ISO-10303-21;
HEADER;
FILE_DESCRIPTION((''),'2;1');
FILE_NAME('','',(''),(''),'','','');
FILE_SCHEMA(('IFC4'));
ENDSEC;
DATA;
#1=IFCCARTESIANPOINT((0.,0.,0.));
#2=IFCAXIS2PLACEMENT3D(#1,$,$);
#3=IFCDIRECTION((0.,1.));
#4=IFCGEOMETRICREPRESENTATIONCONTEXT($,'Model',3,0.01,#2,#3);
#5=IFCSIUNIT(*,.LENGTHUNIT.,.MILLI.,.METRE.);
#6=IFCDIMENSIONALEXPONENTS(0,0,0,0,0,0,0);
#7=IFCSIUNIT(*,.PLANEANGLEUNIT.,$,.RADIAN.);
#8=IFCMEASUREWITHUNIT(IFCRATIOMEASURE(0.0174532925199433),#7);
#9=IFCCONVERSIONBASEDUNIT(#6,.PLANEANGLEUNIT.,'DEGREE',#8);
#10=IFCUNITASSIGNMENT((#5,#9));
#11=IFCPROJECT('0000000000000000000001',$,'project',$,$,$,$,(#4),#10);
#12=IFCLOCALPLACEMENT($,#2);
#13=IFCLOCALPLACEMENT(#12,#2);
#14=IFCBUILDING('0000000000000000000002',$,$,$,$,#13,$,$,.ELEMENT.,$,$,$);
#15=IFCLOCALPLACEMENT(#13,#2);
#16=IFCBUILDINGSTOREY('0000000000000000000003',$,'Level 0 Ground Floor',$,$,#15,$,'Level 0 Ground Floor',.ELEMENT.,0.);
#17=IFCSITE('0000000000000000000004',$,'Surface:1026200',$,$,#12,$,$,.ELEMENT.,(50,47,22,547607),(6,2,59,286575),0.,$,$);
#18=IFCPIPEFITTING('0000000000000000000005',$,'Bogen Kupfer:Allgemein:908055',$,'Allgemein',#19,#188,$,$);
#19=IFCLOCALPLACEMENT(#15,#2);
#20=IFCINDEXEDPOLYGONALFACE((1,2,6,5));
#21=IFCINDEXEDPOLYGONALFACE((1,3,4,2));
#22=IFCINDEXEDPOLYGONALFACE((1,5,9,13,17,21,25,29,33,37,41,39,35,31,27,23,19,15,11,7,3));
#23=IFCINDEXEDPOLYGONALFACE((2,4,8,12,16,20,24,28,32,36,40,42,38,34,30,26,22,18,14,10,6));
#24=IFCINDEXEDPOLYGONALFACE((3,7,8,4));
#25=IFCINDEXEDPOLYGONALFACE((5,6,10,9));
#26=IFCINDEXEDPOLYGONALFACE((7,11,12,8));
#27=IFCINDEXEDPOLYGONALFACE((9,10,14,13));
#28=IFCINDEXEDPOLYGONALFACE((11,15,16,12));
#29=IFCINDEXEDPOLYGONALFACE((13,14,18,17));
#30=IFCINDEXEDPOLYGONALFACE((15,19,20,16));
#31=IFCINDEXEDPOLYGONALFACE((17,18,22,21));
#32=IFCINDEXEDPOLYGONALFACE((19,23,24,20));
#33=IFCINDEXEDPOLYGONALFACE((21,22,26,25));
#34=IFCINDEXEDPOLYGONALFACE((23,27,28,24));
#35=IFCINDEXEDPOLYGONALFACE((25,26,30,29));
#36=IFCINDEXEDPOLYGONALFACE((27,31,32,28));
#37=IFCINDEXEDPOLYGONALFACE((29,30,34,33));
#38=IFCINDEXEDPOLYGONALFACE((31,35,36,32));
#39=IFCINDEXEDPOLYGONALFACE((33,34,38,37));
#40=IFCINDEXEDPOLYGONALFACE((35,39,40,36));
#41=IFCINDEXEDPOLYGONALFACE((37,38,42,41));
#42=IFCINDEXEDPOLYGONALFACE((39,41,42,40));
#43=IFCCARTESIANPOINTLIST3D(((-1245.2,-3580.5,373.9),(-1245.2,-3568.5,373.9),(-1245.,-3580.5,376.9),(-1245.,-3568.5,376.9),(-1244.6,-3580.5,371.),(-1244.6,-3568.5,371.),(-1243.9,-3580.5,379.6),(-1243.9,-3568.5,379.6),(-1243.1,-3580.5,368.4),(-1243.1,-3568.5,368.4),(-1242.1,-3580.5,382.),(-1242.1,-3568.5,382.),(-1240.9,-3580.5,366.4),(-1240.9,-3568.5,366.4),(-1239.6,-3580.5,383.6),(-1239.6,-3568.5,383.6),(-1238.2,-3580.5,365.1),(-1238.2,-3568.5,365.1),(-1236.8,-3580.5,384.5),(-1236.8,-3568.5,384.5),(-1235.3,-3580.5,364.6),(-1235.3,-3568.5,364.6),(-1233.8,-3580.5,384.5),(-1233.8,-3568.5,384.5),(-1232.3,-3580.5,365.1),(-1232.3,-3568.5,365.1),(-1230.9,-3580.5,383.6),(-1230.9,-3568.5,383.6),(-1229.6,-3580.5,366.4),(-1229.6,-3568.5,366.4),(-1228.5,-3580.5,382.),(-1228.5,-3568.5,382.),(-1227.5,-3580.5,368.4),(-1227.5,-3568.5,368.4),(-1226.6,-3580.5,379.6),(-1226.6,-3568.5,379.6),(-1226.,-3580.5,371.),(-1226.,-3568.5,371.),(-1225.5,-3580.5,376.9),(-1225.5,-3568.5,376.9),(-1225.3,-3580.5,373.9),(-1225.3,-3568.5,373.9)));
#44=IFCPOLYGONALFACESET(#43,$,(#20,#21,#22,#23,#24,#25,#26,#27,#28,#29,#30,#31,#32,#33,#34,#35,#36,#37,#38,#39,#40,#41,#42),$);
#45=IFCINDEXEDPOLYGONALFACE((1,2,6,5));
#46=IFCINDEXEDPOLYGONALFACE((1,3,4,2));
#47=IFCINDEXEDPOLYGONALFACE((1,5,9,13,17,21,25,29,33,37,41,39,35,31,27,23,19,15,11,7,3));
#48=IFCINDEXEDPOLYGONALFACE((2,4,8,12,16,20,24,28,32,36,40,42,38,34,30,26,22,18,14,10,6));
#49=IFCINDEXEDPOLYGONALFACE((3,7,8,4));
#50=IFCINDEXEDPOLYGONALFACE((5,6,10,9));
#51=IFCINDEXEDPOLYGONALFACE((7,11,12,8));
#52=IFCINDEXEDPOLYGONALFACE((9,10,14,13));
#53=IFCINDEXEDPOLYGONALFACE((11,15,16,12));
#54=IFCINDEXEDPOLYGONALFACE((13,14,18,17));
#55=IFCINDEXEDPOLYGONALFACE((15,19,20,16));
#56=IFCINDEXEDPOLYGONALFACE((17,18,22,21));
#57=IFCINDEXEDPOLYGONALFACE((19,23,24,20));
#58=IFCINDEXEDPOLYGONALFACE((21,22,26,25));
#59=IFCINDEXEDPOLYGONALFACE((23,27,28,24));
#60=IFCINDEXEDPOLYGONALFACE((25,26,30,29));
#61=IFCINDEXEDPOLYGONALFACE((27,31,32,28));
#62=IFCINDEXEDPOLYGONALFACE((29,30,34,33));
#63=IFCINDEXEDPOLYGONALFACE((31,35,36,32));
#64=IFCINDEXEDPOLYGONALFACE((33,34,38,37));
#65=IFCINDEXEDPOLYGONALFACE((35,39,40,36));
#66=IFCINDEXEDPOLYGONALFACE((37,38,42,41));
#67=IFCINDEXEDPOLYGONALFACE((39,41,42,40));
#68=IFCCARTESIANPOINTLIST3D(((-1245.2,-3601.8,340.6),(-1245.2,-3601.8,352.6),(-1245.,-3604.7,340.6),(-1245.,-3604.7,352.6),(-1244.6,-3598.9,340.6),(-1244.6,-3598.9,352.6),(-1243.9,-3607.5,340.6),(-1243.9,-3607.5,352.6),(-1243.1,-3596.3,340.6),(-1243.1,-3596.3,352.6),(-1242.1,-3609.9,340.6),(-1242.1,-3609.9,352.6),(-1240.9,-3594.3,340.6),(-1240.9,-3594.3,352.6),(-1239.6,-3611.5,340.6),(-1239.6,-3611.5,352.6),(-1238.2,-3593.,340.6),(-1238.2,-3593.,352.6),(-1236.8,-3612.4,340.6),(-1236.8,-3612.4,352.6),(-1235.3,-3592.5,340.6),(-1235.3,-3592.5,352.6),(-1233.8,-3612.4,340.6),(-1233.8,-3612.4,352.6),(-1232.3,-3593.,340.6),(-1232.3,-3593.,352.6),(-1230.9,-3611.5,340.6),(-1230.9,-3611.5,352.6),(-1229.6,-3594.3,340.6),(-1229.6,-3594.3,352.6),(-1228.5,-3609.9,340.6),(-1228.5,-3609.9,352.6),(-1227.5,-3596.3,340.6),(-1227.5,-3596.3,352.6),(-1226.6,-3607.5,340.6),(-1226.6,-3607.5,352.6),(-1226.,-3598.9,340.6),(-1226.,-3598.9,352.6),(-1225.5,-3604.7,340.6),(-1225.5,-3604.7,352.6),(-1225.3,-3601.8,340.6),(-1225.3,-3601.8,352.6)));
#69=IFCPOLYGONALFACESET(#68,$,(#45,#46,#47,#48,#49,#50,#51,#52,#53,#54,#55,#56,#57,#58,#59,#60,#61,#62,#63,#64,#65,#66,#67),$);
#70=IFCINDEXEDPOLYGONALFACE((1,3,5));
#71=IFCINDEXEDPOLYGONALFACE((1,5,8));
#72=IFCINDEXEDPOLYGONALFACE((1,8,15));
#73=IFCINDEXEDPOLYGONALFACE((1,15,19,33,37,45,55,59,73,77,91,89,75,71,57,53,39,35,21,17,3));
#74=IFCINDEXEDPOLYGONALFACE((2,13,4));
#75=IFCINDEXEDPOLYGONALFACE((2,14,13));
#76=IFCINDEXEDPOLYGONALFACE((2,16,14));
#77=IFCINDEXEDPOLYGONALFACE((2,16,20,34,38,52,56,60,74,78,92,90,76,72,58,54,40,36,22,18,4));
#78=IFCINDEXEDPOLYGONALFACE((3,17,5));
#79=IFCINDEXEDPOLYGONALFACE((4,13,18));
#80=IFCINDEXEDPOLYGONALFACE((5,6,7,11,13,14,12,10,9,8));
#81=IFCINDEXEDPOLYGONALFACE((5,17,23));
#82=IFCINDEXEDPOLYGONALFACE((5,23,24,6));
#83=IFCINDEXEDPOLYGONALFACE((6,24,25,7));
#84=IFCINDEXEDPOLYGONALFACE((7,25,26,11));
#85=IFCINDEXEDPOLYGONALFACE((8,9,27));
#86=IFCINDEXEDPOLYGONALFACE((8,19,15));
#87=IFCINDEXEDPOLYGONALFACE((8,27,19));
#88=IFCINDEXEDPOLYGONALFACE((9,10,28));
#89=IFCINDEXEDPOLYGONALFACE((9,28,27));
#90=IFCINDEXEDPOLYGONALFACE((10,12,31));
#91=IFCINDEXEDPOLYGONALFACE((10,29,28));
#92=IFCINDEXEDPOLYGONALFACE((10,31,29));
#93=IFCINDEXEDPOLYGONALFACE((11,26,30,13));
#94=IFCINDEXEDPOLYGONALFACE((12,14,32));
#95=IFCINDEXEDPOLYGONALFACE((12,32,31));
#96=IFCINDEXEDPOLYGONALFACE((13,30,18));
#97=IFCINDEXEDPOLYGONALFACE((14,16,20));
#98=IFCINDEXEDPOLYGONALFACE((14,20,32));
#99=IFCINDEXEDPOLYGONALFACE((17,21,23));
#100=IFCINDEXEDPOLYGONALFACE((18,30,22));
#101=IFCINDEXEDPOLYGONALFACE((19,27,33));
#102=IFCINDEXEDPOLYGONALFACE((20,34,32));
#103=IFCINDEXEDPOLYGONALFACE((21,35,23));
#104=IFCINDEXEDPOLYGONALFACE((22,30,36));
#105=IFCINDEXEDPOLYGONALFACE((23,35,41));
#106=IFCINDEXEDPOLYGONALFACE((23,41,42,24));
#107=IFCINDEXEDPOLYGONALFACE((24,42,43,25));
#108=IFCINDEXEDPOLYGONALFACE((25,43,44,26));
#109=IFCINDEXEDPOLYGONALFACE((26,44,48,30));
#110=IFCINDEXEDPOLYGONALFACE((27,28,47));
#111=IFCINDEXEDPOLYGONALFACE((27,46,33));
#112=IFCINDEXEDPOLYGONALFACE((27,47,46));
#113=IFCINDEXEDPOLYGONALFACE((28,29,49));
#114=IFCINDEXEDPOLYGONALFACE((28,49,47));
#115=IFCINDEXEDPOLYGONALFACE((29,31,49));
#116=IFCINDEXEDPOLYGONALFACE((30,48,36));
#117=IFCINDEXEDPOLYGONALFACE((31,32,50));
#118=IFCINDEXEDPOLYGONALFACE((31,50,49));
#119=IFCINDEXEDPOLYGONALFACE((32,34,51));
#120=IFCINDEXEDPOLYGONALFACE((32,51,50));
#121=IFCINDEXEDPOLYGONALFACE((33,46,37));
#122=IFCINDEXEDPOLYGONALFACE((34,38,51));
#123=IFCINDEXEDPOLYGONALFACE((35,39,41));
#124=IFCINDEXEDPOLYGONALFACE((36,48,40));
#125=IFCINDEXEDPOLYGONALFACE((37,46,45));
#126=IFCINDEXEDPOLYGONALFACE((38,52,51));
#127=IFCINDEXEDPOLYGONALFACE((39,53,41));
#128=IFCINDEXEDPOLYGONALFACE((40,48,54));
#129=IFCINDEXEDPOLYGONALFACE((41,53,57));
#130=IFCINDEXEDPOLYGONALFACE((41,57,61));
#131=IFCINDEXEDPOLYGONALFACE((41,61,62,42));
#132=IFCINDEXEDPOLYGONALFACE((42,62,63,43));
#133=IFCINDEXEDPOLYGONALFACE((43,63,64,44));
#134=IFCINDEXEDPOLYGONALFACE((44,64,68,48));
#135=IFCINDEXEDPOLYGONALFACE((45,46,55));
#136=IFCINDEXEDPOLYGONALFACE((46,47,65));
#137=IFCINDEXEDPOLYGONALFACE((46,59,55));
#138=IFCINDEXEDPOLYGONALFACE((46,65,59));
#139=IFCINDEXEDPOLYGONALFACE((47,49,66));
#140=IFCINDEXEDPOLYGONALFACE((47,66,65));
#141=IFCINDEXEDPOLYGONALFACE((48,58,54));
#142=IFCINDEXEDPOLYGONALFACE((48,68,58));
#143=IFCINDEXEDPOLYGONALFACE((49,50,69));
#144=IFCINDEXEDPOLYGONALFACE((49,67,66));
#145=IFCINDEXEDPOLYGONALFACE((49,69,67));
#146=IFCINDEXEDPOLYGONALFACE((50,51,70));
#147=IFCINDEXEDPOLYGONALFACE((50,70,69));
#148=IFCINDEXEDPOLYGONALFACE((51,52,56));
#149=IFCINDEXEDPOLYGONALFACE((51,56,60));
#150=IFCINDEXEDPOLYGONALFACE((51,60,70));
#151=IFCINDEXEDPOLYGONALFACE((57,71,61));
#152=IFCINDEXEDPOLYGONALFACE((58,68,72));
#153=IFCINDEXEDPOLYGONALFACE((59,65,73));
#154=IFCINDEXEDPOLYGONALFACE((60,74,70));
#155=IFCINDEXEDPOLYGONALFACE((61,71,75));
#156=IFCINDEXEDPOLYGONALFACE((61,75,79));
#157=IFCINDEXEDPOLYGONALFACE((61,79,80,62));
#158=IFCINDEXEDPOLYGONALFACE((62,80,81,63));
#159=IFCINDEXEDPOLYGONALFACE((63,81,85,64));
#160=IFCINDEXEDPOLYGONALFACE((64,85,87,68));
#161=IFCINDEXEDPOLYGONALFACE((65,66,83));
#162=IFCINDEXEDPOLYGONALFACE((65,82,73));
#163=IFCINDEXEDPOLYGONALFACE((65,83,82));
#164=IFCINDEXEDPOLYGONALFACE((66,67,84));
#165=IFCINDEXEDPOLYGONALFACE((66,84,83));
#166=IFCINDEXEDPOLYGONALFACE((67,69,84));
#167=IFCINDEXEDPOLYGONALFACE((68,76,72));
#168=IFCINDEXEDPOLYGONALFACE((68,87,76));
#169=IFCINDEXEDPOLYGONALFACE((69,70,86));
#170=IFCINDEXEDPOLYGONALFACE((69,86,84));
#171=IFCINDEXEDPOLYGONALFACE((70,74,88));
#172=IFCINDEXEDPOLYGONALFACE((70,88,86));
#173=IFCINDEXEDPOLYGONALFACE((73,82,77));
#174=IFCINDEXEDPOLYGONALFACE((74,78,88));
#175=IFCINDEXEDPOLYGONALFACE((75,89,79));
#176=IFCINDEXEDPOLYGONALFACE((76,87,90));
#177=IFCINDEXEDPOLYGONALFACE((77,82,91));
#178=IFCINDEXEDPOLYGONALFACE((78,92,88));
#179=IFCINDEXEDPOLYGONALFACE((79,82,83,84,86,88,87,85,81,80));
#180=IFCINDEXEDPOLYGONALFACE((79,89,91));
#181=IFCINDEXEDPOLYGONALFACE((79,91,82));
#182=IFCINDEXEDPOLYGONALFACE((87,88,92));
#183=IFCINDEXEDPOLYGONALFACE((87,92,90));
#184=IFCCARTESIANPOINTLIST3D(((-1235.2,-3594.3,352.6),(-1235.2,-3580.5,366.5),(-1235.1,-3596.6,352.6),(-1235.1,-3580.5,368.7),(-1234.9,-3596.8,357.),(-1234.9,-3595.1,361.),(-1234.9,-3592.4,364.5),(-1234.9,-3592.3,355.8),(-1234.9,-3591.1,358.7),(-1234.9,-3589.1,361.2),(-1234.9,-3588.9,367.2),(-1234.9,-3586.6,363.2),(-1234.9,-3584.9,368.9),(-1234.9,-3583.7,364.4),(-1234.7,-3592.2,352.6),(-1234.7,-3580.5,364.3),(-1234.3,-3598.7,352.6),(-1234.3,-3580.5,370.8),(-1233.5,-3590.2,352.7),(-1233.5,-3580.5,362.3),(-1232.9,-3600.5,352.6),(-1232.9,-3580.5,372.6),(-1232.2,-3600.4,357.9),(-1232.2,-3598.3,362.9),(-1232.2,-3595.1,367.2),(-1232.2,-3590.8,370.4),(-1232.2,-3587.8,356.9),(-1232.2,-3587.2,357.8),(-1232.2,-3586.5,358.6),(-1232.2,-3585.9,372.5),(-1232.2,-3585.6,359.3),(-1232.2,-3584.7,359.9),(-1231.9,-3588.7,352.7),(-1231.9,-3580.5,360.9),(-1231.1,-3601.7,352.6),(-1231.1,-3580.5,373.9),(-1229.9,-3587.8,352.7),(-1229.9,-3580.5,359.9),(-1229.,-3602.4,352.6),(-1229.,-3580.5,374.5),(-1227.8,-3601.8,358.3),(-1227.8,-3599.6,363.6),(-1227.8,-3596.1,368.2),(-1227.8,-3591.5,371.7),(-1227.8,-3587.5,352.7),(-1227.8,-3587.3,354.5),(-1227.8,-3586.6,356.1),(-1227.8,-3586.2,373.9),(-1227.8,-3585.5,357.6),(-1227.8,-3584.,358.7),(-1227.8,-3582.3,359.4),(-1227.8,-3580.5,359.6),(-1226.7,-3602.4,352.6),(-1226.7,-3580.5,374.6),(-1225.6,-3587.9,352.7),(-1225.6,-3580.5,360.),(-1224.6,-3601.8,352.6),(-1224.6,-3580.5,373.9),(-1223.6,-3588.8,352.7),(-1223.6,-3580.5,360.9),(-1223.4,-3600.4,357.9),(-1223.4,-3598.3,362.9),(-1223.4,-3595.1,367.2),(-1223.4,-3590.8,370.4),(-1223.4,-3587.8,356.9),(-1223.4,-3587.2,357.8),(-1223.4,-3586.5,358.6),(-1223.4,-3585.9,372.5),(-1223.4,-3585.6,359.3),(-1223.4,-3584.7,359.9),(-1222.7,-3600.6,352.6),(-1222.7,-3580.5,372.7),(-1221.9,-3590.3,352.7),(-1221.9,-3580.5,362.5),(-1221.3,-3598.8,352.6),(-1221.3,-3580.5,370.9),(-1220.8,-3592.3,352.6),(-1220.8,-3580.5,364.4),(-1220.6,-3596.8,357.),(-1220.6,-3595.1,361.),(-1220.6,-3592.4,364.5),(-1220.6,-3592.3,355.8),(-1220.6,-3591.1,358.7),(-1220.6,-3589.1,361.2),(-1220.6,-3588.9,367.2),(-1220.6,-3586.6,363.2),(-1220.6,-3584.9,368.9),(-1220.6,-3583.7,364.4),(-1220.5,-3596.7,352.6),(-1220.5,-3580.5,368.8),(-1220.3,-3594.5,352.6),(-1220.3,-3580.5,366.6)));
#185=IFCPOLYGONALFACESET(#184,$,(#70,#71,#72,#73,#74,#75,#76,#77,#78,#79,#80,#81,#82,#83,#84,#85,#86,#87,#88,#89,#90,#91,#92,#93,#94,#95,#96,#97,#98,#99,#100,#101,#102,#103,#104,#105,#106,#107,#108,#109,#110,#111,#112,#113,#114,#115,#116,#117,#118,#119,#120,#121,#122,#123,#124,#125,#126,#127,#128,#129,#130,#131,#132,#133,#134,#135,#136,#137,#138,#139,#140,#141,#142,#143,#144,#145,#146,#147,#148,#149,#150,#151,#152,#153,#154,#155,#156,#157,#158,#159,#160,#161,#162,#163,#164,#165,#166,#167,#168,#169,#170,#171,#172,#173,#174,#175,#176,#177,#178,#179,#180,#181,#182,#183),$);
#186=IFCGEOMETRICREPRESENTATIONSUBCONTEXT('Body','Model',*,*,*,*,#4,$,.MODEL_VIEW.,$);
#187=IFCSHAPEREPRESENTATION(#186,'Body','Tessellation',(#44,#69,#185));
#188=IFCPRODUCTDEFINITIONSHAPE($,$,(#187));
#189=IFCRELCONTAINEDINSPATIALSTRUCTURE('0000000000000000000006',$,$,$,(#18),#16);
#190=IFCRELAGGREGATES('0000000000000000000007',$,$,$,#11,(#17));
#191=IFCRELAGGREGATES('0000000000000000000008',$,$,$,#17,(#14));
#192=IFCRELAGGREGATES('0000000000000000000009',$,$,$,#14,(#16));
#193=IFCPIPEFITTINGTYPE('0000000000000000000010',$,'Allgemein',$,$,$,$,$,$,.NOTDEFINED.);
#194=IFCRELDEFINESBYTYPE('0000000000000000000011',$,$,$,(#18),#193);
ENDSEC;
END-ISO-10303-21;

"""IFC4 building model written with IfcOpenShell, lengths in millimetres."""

from ifc_helpers import new_model, entity, si_unit, converted_unit, direction, frame, frame_2d, origin, place, context, subcontext, project, spatial, circle, extrude, source, transform, mapped, type_object, type_shapes, element, save


model = new_model("IFC4")

# Units and contexts
model_context = context("Model", 3, precision=0.01, world=origin(), true_north=direction((0.0, 1.0)))
body_context = subcontext(model_context, "Body", "Model", "MODEL_VIEW")
ifc_project = project(units=[si_unit("LENGTHUNIT", "METRE", prefix="MILLI"), converted_unit("PLANEANGLEUNIT", "DEGREE", entity("IfcRatioMeasure", 0.0174532925199433), si_unit("PLANEANGLEUNIT", "RADIAN"), dimensions=[0, 0, 0, 0, 0, 0, 0])], contexts=[model_context])

# Site, building, storey
site_placement = place(None, origin())
site = spatial("IfcSite", under=ifc_project, at=site_placement, Name="Surface:1026200", CompositionType="ELEMENT", RefLatitude=(50, 47, 22, 547607), RefLongitude=(6, 2, 59, 286575), RefElevation=0.0)
building_placement = place(site_placement, origin())
building = spatial("IfcBuilding", under=site, at=building_placement, CompositionType="ELEMENT")
storey_placement = place(building_placement, origin())
storey = spatial("IfcBuildingStorey", under=building, at=storey_placement, Name="Level 0 Ground Floor", LongName="Level 0 Ground Floor", CompositionType="ELEMENT", Elevation=0.0)

# Pipe fitting
pipe_fitting_type = type_object("IfcPipeFittingType", Name="Allgemein", PredefinedType="NOTDEFINED")
ifc_direction = entity("IfcDirection", [0.0, 0.0, -1.0])
trimmed_curve = entity("IfcTrimmedCurve", entity("IfcCircle", entity("IfcAxis2Placement2D", entity("IfcCartesianPoint", [-14.5, 0.0]), entity("IfcDirection", [0.0, 1.0])), 14.5), [entity("IfcParameterValue", 270.0)], [entity("IfcParameterValue", 0.0)], True, "PARAMETER")
shared_shape_1 = source(origin(), body_context, "Body", "SolidModel", [
    extrude(circle(Radius=10.0, at=frame_2d((0.0, 0.0), x_axis=(1.0, 0.0))), frame((0.0, 22.0, 0.0), z_axis=(0.0, 1.0, 0.0), x_axis=(-1.0, 0.0, 0.0)), (0.0, 0.0, 1.0), 12.0),
    extrude(circle(Radius=10.0, at=frame_2d((0.0, 0.0), x_axis=(1.0, 0.0))), frame((-34.0, 0.0, 0.0), z_axis=(1.0, 0.0, 0.0), x_axis=(0.0, 1.0, 0.0)), (0.0, 0.0, 1.0), 12.0),
    entity("IfcSurfaceCurveSweptAreaSolid", entity("IfcCircleProfileDef", "AREA", None, entity("IfcAxis2Placement2D", entity("IfcCartesianPoint", [0.0, 7.5]), entity("IfcDirection", [1.0, 0.0])), 7.5), entity("IfcAxis2Placement3D", entity("IfcCartesianPoint", [-7.5, 22.0, 0.0]), ifc_direction, entity("IfcDirection", [1.0, 0.0, 0.0])), trimmed_curve, 0.0, 90.0, entity("IfcSurfaceOfLinearExtrusion", entity("IfcArbitraryOpenProfileDef", "CURVE", None, trimmed_curve), entity("IfcAxis2Placement3D", entity("IfcCartesianPoint", [0.0, 0.0, -304.8])), ifc_direction, 1.0)),
])
type_shapes(pipe_fitting_type, [shared_shape_1])
for number, where, z_axis, x_axis, name in (
    (1, (-1235.3, -3602.5, 374.6), (-1.0, 0.0, 0.0), (0.0, 0.0, 1.0), "Bogen Kupfer:Allgemein:908055"),
):
    element("IfcPipeFitting", number, at=place(storey_placement, frame(where, z_axis=z_axis, x_axis=x_axis)), inside=storey, type_object=pipe_fitting_type, Name=name, ObjectType="Allgemein", context=body_context, shape_type="MappedRepresentation", body=[
        mapped(shared_shape_1, transform((0.0, 0.0, 0.0), scale=1.0)),
    ])

save(model, "model.ifc")
